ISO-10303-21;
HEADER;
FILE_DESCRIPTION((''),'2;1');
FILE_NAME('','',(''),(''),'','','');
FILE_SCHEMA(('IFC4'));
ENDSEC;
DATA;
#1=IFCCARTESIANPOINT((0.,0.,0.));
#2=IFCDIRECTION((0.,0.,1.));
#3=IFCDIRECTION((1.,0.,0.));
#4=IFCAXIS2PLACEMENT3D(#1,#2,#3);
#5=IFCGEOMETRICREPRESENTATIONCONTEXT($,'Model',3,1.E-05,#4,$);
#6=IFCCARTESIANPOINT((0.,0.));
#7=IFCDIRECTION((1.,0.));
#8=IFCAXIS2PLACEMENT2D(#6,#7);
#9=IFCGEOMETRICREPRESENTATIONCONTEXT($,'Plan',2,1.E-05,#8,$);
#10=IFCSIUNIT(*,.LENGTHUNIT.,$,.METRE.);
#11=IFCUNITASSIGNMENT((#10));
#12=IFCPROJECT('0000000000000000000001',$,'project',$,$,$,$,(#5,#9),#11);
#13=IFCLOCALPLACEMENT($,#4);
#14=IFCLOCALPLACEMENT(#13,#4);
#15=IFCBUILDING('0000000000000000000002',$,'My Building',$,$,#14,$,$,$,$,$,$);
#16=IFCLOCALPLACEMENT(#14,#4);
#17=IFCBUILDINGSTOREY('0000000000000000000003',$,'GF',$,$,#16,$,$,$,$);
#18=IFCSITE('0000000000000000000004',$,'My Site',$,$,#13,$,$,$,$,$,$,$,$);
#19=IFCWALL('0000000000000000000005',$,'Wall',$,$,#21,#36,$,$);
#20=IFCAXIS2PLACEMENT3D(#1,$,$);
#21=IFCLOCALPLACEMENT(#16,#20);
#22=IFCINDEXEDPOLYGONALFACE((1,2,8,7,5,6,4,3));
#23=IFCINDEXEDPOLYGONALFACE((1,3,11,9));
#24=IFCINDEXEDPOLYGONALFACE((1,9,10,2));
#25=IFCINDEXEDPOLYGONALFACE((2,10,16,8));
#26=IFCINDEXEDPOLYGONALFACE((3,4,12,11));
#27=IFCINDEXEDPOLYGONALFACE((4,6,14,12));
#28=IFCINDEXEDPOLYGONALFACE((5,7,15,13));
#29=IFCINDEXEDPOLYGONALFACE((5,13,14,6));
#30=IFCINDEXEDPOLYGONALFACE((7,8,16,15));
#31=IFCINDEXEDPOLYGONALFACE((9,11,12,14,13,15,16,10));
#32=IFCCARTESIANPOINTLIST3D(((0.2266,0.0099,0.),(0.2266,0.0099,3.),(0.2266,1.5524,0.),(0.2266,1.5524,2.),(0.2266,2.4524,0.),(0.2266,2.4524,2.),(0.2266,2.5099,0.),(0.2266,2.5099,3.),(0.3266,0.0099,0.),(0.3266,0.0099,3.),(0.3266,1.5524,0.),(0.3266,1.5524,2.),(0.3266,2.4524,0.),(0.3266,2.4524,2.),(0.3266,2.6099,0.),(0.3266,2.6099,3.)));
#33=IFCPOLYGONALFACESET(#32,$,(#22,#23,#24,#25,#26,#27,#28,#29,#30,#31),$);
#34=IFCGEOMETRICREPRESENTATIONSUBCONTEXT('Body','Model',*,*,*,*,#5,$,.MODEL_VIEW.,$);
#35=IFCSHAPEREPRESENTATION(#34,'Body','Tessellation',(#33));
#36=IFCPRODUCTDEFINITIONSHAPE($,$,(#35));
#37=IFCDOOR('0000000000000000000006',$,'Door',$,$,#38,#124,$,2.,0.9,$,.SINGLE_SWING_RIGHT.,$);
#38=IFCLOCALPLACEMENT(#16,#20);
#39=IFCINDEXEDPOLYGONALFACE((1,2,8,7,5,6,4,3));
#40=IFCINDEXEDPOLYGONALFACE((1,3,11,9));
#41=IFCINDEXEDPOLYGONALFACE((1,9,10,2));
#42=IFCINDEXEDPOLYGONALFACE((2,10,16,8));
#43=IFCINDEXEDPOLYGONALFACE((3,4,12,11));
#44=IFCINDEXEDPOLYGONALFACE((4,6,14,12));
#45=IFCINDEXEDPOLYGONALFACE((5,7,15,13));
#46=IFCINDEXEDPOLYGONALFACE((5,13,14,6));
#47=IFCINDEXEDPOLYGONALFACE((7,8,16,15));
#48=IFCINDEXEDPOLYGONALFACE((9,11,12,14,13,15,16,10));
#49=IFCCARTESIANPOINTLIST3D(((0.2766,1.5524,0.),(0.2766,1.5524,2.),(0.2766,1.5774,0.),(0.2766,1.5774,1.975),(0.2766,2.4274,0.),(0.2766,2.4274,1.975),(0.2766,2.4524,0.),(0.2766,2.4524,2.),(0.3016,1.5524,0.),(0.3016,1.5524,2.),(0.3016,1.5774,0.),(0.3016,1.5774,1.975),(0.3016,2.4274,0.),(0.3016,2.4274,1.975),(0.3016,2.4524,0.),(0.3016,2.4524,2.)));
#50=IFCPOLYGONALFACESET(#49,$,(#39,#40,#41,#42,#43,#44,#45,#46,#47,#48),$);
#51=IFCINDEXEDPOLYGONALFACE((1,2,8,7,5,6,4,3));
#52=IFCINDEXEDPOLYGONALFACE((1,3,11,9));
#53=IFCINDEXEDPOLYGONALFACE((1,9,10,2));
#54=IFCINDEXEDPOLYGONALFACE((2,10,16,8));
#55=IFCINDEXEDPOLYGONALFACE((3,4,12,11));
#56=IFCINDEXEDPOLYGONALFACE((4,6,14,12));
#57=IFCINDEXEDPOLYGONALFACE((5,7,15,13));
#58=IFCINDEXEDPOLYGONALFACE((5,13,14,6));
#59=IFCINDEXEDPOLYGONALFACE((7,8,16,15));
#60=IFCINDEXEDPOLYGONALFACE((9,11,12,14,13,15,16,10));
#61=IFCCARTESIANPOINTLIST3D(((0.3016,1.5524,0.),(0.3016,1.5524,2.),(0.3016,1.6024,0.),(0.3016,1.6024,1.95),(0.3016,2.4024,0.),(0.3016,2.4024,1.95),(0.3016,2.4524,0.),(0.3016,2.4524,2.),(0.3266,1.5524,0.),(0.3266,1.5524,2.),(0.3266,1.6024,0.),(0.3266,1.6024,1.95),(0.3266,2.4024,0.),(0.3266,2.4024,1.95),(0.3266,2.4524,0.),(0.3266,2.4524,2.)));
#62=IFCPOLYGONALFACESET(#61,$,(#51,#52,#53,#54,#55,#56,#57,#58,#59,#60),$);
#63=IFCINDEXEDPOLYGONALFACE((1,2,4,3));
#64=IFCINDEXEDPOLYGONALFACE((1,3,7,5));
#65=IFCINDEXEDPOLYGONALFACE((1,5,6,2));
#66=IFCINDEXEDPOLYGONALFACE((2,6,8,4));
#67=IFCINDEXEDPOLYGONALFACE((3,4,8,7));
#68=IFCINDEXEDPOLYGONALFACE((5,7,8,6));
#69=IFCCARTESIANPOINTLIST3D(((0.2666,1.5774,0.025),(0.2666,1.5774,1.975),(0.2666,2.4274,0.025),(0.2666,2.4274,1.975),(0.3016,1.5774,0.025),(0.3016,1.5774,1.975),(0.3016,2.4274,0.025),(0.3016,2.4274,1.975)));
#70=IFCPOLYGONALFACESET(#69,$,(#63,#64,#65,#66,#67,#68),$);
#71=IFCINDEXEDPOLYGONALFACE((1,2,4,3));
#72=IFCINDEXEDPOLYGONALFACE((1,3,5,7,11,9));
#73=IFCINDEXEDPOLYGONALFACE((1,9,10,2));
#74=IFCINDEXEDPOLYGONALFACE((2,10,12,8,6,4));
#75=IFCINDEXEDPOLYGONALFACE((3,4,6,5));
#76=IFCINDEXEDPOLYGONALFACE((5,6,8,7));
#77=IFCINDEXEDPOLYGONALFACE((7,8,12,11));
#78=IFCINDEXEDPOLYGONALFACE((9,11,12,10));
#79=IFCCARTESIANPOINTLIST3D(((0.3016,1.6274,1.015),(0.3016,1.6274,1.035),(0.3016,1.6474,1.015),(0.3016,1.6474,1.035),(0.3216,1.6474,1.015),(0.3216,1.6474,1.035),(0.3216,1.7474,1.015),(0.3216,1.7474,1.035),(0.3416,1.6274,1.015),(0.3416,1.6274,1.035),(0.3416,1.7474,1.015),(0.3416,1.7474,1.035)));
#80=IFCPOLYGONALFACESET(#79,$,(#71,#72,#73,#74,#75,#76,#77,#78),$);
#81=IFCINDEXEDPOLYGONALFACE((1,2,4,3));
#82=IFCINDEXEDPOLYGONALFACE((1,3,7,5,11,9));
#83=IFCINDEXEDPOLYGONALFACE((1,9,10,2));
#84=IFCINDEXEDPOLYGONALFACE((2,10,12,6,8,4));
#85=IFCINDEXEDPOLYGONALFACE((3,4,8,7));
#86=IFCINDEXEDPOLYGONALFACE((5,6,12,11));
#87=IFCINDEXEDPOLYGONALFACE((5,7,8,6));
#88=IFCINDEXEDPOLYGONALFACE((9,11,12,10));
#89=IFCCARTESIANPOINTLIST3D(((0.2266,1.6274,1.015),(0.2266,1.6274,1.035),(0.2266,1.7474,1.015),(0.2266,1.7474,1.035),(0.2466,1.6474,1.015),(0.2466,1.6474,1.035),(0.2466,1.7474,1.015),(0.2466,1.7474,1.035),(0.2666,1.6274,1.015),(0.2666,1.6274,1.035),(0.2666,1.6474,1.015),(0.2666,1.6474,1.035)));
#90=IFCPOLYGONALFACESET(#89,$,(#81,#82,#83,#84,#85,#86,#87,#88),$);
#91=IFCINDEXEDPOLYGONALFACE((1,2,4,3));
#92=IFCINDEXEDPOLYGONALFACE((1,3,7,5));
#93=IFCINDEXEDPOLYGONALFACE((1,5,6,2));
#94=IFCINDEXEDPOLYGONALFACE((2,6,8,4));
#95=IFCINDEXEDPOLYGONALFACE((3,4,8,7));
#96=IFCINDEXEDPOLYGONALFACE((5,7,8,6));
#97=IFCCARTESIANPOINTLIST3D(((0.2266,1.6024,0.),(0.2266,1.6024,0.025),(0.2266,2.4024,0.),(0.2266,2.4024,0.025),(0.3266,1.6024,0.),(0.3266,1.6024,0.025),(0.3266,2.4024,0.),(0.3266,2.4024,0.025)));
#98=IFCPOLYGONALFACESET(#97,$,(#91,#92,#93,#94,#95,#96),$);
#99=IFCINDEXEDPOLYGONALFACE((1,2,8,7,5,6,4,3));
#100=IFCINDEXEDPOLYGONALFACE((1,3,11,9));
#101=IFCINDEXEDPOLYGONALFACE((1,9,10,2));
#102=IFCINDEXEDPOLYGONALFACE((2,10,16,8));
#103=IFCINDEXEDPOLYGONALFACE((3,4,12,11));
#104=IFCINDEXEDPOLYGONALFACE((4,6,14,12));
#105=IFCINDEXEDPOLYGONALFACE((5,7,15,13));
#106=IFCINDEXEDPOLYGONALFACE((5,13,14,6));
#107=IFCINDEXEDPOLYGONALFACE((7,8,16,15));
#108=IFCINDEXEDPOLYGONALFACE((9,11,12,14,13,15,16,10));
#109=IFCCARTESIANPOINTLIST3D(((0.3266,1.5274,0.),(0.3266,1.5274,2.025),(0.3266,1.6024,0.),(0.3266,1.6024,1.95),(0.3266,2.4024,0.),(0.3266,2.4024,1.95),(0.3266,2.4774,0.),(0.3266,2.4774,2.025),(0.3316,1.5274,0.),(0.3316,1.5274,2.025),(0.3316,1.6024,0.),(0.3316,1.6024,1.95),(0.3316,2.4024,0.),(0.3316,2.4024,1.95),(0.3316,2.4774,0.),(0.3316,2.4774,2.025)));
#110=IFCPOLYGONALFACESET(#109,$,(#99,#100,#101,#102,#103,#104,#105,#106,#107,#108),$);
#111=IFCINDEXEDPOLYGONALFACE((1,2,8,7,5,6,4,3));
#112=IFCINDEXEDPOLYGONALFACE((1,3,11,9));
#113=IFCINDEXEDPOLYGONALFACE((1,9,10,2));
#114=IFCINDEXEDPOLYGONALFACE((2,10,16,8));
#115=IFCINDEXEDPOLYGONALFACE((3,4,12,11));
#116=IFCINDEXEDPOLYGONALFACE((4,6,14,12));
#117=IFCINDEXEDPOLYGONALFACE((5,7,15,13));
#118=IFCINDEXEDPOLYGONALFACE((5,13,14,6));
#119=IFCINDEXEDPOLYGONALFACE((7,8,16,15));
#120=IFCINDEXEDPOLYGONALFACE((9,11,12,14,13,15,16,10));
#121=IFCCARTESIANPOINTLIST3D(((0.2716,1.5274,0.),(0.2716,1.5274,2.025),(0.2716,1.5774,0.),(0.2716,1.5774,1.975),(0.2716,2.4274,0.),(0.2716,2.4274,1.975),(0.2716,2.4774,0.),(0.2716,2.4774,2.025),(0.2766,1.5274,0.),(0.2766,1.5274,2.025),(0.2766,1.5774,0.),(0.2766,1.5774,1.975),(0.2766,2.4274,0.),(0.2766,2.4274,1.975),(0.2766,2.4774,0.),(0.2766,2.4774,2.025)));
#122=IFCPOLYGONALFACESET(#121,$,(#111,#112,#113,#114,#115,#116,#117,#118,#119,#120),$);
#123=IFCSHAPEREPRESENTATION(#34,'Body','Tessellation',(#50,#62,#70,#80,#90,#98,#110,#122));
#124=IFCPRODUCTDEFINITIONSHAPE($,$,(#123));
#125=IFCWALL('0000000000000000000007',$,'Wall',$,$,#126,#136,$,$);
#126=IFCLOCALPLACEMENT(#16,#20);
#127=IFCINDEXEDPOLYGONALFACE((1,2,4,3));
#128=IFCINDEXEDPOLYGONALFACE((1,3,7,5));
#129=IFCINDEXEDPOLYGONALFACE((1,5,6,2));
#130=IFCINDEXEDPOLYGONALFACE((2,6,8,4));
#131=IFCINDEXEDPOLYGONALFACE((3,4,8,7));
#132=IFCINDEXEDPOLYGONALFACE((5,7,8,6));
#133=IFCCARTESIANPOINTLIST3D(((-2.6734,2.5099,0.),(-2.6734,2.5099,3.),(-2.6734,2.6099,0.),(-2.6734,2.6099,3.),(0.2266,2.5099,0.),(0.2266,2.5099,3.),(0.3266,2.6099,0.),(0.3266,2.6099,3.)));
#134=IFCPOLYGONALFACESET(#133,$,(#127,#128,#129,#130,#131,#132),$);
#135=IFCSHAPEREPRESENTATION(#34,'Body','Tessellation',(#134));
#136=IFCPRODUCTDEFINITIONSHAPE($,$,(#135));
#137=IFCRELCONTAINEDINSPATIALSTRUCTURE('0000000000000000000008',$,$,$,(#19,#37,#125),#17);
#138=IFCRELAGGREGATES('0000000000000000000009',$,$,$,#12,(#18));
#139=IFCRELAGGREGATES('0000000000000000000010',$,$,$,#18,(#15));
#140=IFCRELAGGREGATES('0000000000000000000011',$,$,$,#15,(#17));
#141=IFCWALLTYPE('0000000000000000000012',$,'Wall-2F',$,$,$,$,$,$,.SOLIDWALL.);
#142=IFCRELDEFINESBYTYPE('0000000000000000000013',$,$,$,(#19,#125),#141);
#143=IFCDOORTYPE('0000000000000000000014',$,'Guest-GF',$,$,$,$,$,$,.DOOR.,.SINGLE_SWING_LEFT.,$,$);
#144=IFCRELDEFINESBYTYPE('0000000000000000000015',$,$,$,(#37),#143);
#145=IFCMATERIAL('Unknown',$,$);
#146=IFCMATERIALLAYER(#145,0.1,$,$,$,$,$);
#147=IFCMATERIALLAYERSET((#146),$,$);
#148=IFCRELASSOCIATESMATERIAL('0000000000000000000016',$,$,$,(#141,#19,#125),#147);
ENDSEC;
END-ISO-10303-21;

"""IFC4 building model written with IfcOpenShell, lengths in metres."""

from ifc_helpers import new_model, entity, si_unit, frame, origin_with_axes, origin_2d_with_axis, place, context, subcontext, project, spatial, line, indexed_curve, outline, extrude, shape, source, transform, mapped, material, layer, layer_set, layer_usage, type_object, type_shapes, element, fill, save


model = new_model("IFC4")

# Units and contexts
model_context = context("Model", 3, precision=1e-05, world=origin_with_axes())
plan_context = context("Plan", 2, precision=1e-05, world=origin_2d_with_axis())
body_context_1 = subcontext(model_context, "Body", "Model", "MODEL_VIEW")
body_context_2 = subcontext(plan_context, "Body", "Plan", "PLAN_VIEW")
ifc_project = project(units=[si_unit("LENGTHUNIT", "METRE")], contexts=[model_context, plan_context])

# Site, building, storey
site_placement = place(None, origin_with_axes())
site = spatial("IfcSite", under=ifc_project, at=site_placement, Name="My Site")
building_placement = place(site_placement, origin_with_axes())
building = spatial("IfcBuilding", under=site, at=building_placement, Name="My Building")
storey_placement = place(building_placement, origin_with_axes())
storey = spatial("IfcBuildingStorey", under=building, at=storey_placement, Name="GF")

# Shared definitions
ifc_material = material(Name="Unknown")

# Shared definitions
ifc_layer_1 = layer(ifc_material, 0.1)
ifc_layer_set_1 = layer_set([ifc_layer_1])
wall_type = type_object("IfcWallType", Name="Wall-2F", PredefinedType="SOLIDWALL", material=ifc_layer_set_1)

# Wall, opening, door
ifc_layer_usage_1 = layer_usage(ifc_layer_set_1, "AXIS2", "POSITIVE", 0.0)
wall_1_placement = place(storey_placement, frame((0.3266, 0.0099, 0.0), z_axis=(0.0, 0.0, 1.0), x_axis=(0.0, 1.0, 0.0)))
wall_1 = element("IfcWall", 1, at=wall_1_placement, inside=storey, type_object=wall_type, material=ifc_layer_usage_1, Name="Wall", context=body_context_1, shape_type="SweptSolid", body=[
    extrude(outline(indexed_curve([(0.0, 0.0), (0.0, 0.1), (2.5, 0.1), (2.6, 0.0)], segments=[line(1, 2, 3, 4, 1)])), origin_with_axes(), (0.0, 0.0, 1.0), 3.0),
])
shared_shape_1 = source(origin_with_axes(), body_context_1, "Body", "SweptSolid", [
    extrude(outline(indexed_curve([(0.0, 0.0), (0.9, 0.0), (0.9, 2.0), (0.0, 2.0)], segments=[line(1, 2, 3, 4, 1)])), frame((0.0, -0.6, 0.0), z_axis=(0.0, -1.0, 0.0), x_axis=(1.0, 0.0, 0.0)), (0.0, 0.0, -1.0), 1.2),
])
opening_1_placement = place(wall_1_placement, frame((1.5425, 0.0, 0.0), z_axis=(0.0, 0.0, 1.0), x_axis=(1.0, 0.0, 0.0)))
opening_1 = element("IfcOpeningElement", 2, at=opening_1_placement, cuts=wall_1, PredefinedType="OPENING", context=body_context_1, shape_type="MappedRepresentation", body=[
    mapped(shared_shape_1, transform((0.0, 0.0, 0.0), x_axis=(1.0, 0.0, 0.0), y_axis=(0.0, 1.0, 0.0), z_axis=(0.0, 0.0, 1.0), scale=1.0)),
])
door_type_1 = type_object("IfcDoorType", Name="Guest-GF", OperationType="SINGLE_SWING_LEFT", PredefinedType="DOOR")
shared_shape_2 = source(origin_with_axes(), body_context_1, "Body", "SweptSolid", [
    extrude(outline(indexed_curve([(0.0, 0.0), (0.0, 2.0), (0.9, 2.0), (0.9, 0.0), (0.875, 0.0), (0.875, 1.975), (0.025, 1.975), (0.025, 0.0)], segments=[line(1, 2, 3, 4, 5, 6, 7, 8, 1)])), frame((0.0, 0.025, 0.0), z_axis=(0.0, -1.0, 0.0), x_axis=(1.0, 0.0, 0.0)), (0.0, 0.0, -1.0), 0.025),
    extrude(outline(indexed_curve([(0.0, 0.0), (0.0, 2.0), (0.9, 2.0), (0.9, 0.0), (0.85, 0.0), (0.85, 1.95), (0.05, 1.95), (0.05, 0.0)], segments=[line(1, 2, 3, 4, 5, 6, 7, 8, 1)])), frame((0.0, 0.0, 0.0), z_axis=(0.0, -1.0, 0.0), x_axis=(1.0, 0.0, 0.0)), (0.0, 0.0, -1.0), 0.025),
    extrude(outline(indexed_curve([(0.0, 0.0), (0.85, 0.0), (0.85, 0.035), (0.0, 0.035)], segments=[line(1, 2, 3, 4, 1)])), frame((0.025, 0.025, 0.025), z_axis=(0.0, 0.0, 1.0), x_axis=(1.0, 0.0, 0.0)), (0.0, 0.0, 1.0), 1.95),
    extrude(outline(indexed_curve([(0.0, 0.0), (0.0, -0.04), (0.12, -0.04), (0.12, -0.02), (0.02, -0.02), (0.02, 0.0)], segments=[line(1, 2, 3, 4, 5, 6, 1)])), frame((0.075, 0.025, 1.015), z_axis=(0.0, 0.0, 1.0), x_axis=(1.0, 0.0, 0.0)), (0.0, 0.0, 1.0), 0.02),
    extrude(outline(indexed_curve([(0.0, 0.0), (0.0, 0.04), (0.12, 0.04), (0.12, 0.02), (0.02, 0.02), (0.02, 0.0)], segments=[line(1, 2, 3, 4, 5, 6, 1)])), frame((0.075, 0.06, 1.015), z_axis=(0.0, 0.0, 1.0), x_axis=(1.0, 0.0, 0.0)), (0.0, 0.0, 1.0), 0.02),
    extrude(outline(indexed_curve([(0.0, 0.0), (0.8, 0.0), (0.8, 0.1), (0.0, 0.1)], segments=[line(1, 2, 3, 4, 1)])), frame((0.05, 0.0, 0.0), z_axis=(0.0, 0.0, 1.0), x_axis=(1.0, 0.0, 0.0)), (0.0, 0.0, 1.0), 0.025),
    extrude(outline(indexed_curve([(0.0, 0.0), (0.0, 2.025), (0.95, 2.025), (0.95, 0.0), (0.875, 0.0), (0.875, 1.95), (0.075, 1.95), (0.075, 0.0)], segments=[line(1, 2, 3, 4, 5, 6, 7, 8, 1)])), frame((-0.025, -0.005, 0.0), z_axis=(0.0, -1.0, 0.0), x_axis=(1.0, 0.0, 0.0)), (0.0, 0.0, -1.0), 0.005),
    extrude(outline(indexed_curve([(0.0, 0.0), (0.0, 2.025), (0.95, 2.025), (0.95, 0.0), (0.9, 0.0), (0.9, 1.975), (0.05, 1.975), (0.05, 0.0)], segments=[line(1, 2, 3, 4, 5, 6, 7, 8, 1)])), frame((-0.025, 0.05, 0.0), z_axis=(0.0, -1.0, 0.0), x_axis=(1.0, 0.0, 0.0)), (0.0, 0.0, -1.0), 0.005),
])
shared_shape_3 = source(origin_with_axes(), body_context_2, "Body", "Curve2D", [
    entity("IfcIndexedPolyCurve", entity("IfcCartesianPointList2D", [[0.0, 0.0], [0.0, 0.05], [0.025, 0.05], [0.025, 0.025], [0.05, 0.025], [0.05, 0.0]]), [entity("IfcLineIndex", [1, 2, 3, 4, 5, 6, 1])]),
    entity("IfcIndexedPolyCurve", entity("IfcCartesianPointList2D", [[0.9, 0.0], [0.9, 0.05], [0.875, 0.05], [0.875, 0.025], [0.85, 0.025], [0.85, 0.0]]), [entity("IfcLineIndex", [1, 2, 3, 4, 5, 6, 1])]),
    entity("IfcTrimmedCurve", entity("IfcEllipse", entity("IfcAxis2Placement2D", entity("IfcCartesianPoint", [0.84, 0.05]), entity("IfcDirection", [1.0, 0.0])), 0.815, 0.85), [entity("IfcCartesianPoint", [0.84, 0.9])], [entity("IfcCartesianPoint", [0.025, 0.05])], True, "CARTESIAN"),
    entity("IfcIndexedPolyCurve", entity("IfcCartesianPointList2D", [[0.875, 0.05], [0.84, 0.05], [0.84, 0.9], [0.875, 0.9]]), [entity("IfcLineIndex", [1, 2, 3, 4, 1])]),
])
type_shapes(door_type_1, [shared_shape_2, shared_shape_3])
door_1_placement = place(opening_1_placement, frame((0.0, 0.0, 0.0), z_axis=(0.0, 0.0, 1.0), x_axis=(1.0, 0.0, 0.0)))
door_1 = element("IfcDoor", 3, at=door_1_placement, inside=storey, type_object=door_type_1, Name="Door", OperationType="SINGLE_SWING_RIGHT", OverallHeight=2.0, OverallWidth=0.9, shapes=[
    shape(body_context_1, "Body", "MappedRepresentation", [mapped(shared_shape_2, transform((0.0, 0.0, 0.0), x_axis=(1.0, 0.0, 0.0), y_axis=(0.0, 1.0, 0.0), z_axis=(0.0, 0.0, 1.0), scale=1.0))]),
    shape(body_context_2, "Body", "MappedRepresentation", [mapped(shared_shape_3, transform((0.0, 0.0, 0.0), x_axis=(1.0, 0.0, 0.0), y_axis=(0.0, 1.0, 0.0), z_axis=(0.0, 0.0, 1.0), scale=1.0))]),
])
fill(opening_1, door_1)

# Wall
ifc_layer_usage_2 = layer_usage(ifc_layer_set_1, "AXIS2", "POSITIVE", 0.0)
wall_2_placement = place(storey_placement, frame((0.3266, 2.6099, 0.0), z_axis=(0.0, 0.0, 1.0), x_axis=(-1.0, 0.0, 0.0)))
element("IfcWall", 4, at=wall_2_placement, inside=storey, type_object=wall_type, material=ifc_layer_usage_2, Name="Wall", context=body_context_1, shape_type="SweptSolid", body=[
    extrude(outline(indexed_curve([(0.0, 0.0), (0.1, 0.1), (3.0, 0.1), (3.0, 0.0)], segments=[line(1, 2, 3, 4, 1)])), origin_with_axes(), (0.0, 0.0, 1.0), 3.0),
])

save(model, "model.ifc")
